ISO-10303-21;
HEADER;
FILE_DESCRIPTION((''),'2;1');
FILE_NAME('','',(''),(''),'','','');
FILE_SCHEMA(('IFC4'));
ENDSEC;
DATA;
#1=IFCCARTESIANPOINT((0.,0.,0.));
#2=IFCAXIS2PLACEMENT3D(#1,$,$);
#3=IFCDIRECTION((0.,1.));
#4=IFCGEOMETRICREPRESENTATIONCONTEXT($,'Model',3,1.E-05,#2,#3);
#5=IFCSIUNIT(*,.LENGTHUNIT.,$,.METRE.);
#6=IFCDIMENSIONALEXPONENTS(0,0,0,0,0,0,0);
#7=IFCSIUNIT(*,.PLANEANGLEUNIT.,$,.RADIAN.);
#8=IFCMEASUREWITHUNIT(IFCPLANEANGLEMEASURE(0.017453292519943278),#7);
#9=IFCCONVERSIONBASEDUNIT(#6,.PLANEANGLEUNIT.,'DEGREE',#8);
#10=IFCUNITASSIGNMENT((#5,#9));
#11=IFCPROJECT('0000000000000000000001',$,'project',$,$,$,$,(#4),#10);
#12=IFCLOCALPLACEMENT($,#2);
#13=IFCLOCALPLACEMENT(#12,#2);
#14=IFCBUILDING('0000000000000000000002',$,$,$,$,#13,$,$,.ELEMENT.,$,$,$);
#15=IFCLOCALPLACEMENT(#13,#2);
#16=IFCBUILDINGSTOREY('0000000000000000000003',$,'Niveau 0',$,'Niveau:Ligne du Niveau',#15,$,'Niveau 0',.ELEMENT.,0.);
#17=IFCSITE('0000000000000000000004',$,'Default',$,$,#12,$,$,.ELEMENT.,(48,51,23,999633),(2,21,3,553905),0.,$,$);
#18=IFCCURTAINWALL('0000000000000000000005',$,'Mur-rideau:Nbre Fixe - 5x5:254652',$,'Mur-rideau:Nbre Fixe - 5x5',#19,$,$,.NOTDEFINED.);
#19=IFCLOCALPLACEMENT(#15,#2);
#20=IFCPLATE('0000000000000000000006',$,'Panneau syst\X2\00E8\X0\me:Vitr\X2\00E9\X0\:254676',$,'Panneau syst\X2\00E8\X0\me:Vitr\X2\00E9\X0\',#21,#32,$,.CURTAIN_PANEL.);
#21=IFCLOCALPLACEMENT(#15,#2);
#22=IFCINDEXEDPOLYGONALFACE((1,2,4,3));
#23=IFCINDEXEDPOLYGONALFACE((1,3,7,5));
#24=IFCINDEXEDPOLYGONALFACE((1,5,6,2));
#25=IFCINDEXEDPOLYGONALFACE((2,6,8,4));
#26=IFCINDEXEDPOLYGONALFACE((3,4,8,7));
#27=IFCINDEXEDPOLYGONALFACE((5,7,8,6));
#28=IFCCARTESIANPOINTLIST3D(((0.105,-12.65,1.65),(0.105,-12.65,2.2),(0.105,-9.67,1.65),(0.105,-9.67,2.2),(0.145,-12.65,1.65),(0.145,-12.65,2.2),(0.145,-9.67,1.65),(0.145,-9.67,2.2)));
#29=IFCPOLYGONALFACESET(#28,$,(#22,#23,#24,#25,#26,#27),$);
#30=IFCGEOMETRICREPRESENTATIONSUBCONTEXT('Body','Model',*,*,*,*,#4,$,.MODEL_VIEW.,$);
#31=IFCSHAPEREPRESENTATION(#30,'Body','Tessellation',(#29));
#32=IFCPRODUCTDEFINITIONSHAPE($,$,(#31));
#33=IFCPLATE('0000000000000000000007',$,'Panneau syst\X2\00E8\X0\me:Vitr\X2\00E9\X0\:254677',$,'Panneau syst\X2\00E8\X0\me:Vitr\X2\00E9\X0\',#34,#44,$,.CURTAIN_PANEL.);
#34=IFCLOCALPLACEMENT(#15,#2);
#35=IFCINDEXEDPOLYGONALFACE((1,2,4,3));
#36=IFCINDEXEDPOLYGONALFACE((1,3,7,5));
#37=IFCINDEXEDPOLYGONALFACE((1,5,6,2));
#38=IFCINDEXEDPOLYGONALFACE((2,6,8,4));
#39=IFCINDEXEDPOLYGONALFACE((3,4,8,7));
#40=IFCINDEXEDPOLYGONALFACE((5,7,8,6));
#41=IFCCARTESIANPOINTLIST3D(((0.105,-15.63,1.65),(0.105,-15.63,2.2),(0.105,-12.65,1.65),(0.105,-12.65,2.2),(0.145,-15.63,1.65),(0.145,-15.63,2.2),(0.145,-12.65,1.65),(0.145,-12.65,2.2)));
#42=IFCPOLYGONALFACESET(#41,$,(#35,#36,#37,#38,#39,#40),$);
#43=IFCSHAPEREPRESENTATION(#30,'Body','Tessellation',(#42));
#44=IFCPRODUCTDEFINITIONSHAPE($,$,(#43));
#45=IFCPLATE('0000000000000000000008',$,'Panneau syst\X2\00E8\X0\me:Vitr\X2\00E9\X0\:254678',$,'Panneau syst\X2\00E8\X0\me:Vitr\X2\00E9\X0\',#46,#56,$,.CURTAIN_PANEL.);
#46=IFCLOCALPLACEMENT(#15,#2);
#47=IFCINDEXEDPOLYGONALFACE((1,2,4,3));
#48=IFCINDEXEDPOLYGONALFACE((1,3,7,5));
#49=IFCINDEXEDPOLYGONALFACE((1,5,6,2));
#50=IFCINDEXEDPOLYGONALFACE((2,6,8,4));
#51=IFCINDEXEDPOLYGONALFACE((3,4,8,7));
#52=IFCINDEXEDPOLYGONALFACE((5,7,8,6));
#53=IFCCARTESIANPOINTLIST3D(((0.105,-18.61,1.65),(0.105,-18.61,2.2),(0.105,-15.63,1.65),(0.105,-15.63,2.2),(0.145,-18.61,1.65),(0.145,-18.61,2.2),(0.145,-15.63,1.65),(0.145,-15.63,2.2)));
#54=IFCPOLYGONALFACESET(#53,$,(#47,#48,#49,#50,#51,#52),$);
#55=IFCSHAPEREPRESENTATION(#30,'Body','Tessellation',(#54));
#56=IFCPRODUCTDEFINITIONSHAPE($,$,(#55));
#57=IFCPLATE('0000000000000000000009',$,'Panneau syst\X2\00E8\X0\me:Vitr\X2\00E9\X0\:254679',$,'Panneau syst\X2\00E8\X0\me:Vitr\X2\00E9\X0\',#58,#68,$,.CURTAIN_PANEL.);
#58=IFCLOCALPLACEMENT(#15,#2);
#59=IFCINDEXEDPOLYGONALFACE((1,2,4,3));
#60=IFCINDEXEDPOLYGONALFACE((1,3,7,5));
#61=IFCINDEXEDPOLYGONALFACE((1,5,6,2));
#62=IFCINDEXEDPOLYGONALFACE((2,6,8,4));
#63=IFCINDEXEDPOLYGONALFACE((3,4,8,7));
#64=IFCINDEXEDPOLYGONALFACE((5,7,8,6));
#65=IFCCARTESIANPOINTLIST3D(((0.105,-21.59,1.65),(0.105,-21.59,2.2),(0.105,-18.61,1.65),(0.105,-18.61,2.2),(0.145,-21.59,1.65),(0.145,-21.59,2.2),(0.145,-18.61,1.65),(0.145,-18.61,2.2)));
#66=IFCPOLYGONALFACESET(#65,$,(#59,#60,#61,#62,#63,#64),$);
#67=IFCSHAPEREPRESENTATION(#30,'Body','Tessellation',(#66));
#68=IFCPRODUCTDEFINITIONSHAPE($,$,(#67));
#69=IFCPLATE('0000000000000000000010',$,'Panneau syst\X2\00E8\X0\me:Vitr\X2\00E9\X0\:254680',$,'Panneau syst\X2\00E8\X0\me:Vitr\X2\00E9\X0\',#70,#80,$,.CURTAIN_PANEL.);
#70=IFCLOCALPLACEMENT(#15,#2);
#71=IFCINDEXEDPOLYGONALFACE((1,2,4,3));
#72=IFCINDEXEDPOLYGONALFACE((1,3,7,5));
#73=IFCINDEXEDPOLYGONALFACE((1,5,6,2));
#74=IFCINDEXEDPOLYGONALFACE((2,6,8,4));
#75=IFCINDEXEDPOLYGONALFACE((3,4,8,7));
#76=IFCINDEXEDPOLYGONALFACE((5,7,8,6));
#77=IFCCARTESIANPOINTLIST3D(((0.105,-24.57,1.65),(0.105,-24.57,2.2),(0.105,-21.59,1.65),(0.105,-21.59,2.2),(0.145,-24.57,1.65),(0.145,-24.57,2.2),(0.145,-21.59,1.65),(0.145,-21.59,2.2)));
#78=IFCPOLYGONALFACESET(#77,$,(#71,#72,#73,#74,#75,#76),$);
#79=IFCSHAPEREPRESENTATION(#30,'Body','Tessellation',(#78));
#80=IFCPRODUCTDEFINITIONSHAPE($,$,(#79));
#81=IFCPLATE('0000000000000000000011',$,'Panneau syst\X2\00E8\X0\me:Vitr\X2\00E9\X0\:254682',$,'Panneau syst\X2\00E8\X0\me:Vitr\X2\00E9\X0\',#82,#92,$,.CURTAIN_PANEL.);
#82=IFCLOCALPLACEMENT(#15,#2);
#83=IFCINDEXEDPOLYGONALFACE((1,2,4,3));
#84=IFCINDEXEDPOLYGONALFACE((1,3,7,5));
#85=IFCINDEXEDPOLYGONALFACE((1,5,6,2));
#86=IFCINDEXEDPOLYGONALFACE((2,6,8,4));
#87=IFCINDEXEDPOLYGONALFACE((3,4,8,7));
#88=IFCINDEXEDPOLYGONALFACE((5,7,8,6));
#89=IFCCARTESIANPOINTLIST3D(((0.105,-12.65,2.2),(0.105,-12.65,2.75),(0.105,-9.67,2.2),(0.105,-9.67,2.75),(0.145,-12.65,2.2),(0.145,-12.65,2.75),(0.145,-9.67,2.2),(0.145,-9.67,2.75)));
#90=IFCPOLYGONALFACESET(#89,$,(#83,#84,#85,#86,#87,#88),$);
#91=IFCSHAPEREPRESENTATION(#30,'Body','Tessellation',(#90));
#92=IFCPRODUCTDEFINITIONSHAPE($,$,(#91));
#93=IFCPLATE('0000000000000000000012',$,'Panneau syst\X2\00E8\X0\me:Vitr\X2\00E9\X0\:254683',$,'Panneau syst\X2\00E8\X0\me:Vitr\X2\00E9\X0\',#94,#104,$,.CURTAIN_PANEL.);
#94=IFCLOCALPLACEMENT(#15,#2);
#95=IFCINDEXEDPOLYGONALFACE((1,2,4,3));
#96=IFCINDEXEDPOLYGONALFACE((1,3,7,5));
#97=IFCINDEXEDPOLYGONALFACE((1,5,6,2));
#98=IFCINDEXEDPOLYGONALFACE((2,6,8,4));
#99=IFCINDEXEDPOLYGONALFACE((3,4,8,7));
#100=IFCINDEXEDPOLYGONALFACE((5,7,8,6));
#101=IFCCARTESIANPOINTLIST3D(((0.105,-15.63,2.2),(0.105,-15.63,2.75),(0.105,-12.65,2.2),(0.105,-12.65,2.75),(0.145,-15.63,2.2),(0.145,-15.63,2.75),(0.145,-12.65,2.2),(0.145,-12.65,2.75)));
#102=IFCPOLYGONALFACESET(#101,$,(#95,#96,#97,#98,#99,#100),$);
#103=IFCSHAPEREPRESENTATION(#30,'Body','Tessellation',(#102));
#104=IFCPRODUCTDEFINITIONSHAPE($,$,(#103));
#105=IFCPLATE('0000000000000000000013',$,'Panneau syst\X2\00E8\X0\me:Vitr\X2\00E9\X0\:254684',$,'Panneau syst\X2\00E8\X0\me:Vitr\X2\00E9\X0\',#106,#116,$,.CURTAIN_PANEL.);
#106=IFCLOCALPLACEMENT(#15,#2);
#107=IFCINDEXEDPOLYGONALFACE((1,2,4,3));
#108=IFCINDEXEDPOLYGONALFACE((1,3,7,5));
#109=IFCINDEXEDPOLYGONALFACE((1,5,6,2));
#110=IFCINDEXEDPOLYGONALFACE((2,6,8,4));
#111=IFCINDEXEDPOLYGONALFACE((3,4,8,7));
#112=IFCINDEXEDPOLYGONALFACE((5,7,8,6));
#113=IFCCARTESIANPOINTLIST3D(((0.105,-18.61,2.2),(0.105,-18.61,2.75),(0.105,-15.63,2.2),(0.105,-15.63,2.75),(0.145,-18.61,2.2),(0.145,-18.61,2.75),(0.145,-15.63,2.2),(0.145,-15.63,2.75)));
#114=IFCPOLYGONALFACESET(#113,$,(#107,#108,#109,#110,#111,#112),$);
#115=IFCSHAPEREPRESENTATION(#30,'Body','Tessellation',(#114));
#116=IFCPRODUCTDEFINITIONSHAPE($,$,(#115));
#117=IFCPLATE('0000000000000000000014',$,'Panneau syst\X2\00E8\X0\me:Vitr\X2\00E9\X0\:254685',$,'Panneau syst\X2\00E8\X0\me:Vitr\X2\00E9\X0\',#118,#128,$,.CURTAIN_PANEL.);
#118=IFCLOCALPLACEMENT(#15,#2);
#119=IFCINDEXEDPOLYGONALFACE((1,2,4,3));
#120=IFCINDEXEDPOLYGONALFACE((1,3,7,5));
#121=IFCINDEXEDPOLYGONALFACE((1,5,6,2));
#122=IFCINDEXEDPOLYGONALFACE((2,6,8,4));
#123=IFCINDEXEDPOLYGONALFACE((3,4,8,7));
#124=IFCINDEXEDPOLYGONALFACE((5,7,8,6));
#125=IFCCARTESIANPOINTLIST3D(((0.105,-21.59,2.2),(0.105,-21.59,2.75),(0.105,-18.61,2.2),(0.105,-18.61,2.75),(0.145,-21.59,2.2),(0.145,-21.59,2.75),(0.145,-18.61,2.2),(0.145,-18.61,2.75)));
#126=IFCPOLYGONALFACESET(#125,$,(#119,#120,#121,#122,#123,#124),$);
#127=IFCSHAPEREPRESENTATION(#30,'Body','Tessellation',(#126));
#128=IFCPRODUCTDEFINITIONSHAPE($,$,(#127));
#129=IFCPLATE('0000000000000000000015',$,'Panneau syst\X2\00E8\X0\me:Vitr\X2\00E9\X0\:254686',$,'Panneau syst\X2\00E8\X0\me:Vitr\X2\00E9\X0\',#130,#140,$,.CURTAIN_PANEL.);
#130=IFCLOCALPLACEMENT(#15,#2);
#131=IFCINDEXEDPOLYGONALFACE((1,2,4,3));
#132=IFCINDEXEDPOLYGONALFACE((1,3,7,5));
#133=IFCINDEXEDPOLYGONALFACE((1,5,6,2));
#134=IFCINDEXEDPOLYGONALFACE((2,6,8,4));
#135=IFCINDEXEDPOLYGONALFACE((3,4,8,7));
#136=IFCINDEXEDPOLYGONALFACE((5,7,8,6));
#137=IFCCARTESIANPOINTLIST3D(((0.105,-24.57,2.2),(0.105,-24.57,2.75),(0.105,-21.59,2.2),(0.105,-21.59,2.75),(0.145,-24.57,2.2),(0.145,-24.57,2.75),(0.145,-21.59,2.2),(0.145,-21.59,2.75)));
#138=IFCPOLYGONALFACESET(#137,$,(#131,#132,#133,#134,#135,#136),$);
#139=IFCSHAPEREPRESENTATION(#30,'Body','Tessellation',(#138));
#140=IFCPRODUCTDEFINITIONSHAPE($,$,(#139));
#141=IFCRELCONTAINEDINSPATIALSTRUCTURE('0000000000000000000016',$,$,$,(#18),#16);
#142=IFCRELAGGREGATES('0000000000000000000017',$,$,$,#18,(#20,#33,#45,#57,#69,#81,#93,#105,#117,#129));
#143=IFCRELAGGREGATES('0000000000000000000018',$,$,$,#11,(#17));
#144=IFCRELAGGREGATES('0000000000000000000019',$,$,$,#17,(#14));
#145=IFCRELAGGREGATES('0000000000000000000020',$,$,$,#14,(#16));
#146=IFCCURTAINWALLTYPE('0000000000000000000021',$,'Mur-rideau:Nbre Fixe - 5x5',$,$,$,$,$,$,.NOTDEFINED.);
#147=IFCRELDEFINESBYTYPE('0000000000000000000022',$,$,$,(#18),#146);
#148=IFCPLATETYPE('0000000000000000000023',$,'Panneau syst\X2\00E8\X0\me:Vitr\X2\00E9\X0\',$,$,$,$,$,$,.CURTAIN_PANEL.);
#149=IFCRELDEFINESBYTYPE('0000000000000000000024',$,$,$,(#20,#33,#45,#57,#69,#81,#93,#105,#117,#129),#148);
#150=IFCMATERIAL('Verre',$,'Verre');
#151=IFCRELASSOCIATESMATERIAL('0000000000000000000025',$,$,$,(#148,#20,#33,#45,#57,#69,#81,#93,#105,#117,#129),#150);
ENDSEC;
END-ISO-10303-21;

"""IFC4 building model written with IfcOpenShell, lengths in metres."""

from ifc_helpers import new_model, entity, si_unit, converted_unit, direction, frame, origin, place, context, subcontext, project, spatial, indexed_curve, outline, extrude, source, transform, mapped, material, type_object, type_shapes, element, aggregate, save


model = new_model("IFC4")

# Units and contexts
model_context = context("Model", 3, precision=1e-05, world=origin(), true_north=direction((0.0, 1.0)))
body_context = subcontext(model_context, "Body", "Model", "MODEL_VIEW")
ifc_project = project(units=[si_unit("LENGTHUNIT", "METRE"), converted_unit("PLANEANGLEUNIT", "DEGREE", entity("IfcPlaneAngleMeasure", 0.017453292519943278), si_unit("PLANEANGLEUNIT", "RADIAN"), dimensions=[0, 0, 0, 0, 0, 0, 0])], contexts=[model_context])

# Site, building, storey
site_placement = place(None, origin())
site = spatial("IfcSite", under=ifc_project, at=site_placement, Name="Default", CompositionType="ELEMENT", RefLatitude=(48, 51, 23, 999633), RefLongitude=(2, 21, 3, 553905), RefElevation=0.0)
building_placement = place(site_placement, origin())
building = spatial("IfcBuilding", under=site, at=building_placement, CompositionType="ELEMENT")
storey_placement = place(building_placement, origin())
storey = spatial("IfcBuildingStorey", under=building, at=storey_placement, Name="Niveau 0", ObjectType="Niveau:Ligne du Niveau", LongName="Niveau 0", CompositionType="ELEMENT", Elevation=0.0)

# Curtain wall, plates
curtain_wall_type = type_object("IfcCurtainWallType", Name="Mur-rideau:Nbre Fixe - 5x5", PredefinedType="NOTDEFINED")
curtain_wall_placement = place(storey_placement, origin())
curtain_wall = element("IfcCurtainWall", 1, at=curtain_wall_placement, inside=storey, type_object=curtain_wall_type, Name="Mur-rideau:Nbre Fixe - 5x5:254652", ObjectType="Mur-rideau:Nbre Fixe - 5x5", PredefinedType="NOTDEFINED")
ifc_material = material(Name="Verre", Category="Verre")
plate_type = type_object("IfcPlateType", Name="Panneau système:Vitré", PredefinedType="CURTAIN_PANEL", material=ifc_material)
shared_shape = source(origin(), body_context, "Body", "SweptSolid", [
    extrude(outline(indexed_curve([(-0.02, -1.49), (0.02, -1.49), (0.02, 1.49), (-0.02, 1.49), (-0.02, -1.49)], self_intersect=False)), frame((1.49, 0.02, 0.0), z_axis=(0.0, 0.0, 1.0), x_axis=(0.0, 1.0, 0.0)), (0.0, 0.0, 1.0), 0.55),
])
type_shapes(plate_type, [shared_shape])
plate_1_placement = place(curtain_wall_placement, frame((0.105, -9.67, 1.65), z_axis=(0.0, 0.0, 1.0), x_axis=(0.0, -1.0, 0.0)))
plate_1 = element("IfcPlate", 2, at=plate_1_placement, type_object=plate_type, material=ifc_material, Name="Panneau système:Vitré:254676", ObjectType="Panneau système:Vitré", PredefinedType="CURTAIN_PANEL", context=body_context, shape_type="MappedRepresentation", body=[
    mapped(shared_shape, transform((0.0, 0.0, 0.0), scale=1.0)),
])
plate_2_placement = place(curtain_wall_placement, frame((0.105, -12.65, 1.65), z_axis=(0.0, 0.0, 1.0), x_axis=(0.0, -1.0, 0.0)))
plate_2 = element("IfcPlate", 3, at=plate_2_placement, type_object=plate_type, material=ifc_material, Name="Panneau système:Vitré:254677", ObjectType="Panneau système:Vitré", PredefinedType="CURTAIN_PANEL", context=body_context, shape_type="MappedRepresentation", body=[
    mapped(shared_shape, transform((0.0, 0.0, 0.0), scale=1.0)),
])
plate_3_placement = place(curtain_wall_placement, frame((0.105, -15.63, 1.65), z_axis=(0.0, 0.0, 1.0), x_axis=(0.0, -1.0, 0.0)))
plate_3 = element("IfcPlate", 4, at=plate_3_placement, type_object=plate_type, material=ifc_material, Name="Panneau système:Vitré:254678", ObjectType="Panneau système:Vitré", PredefinedType="CURTAIN_PANEL", context=body_context, shape_type="MappedRepresentation", body=[
    mapped(shared_shape, transform((0.0, 0.0, 0.0), scale=1.0)),
])
plate_4_placement = place(curtain_wall_placement, frame((0.105, -18.61, 1.65), z_axis=(0.0, 0.0, 1.0), x_axis=(0.0, -1.0, 0.0)))
plate_4 = element("IfcPlate", 5, at=plate_4_placement, type_object=plate_type, material=ifc_material, Name="Panneau système:Vitré:254679", ObjectType="Panneau système:Vitré", PredefinedType="CURTAIN_PANEL", context=body_context, shape_type="MappedRepresentation", body=[
    mapped(shared_shape, transform((0.0, 0.0, 0.0), scale=1.0)),
])
plate_5_placement = place(curtain_wall_placement, frame((0.105, -21.59, 1.65), z_axis=(0.0, 0.0, 1.0), x_axis=(0.0, -1.0, 0.0)))
plate_5 = element("IfcPlate", 6, at=plate_5_placement, type_object=plate_type, material=ifc_material, Name="Panneau système:Vitré:254680", ObjectType="Panneau système:Vitré", PredefinedType="CURTAIN_PANEL", context=body_context, shape_type="MappedRepresentation", body=[
    mapped(shared_shape, transform((0.0, 0.0, 0.0), scale=1.0)),
])
plate_6_placement = place(curtain_wall_placement, frame((0.105, -9.67, 2.2), z_axis=(0.0, 0.0, 1.0), x_axis=(0.0, -1.0, 0.0)))
plate_6 = element("IfcPlate", 7, at=plate_6_placement, type_object=plate_type, material=ifc_material, Name="Panneau système:Vitré:254682", ObjectType="Panneau système:Vitré", PredefinedType="CURTAIN_PANEL", context=body_context, shape_type="MappedRepresentation", body=[
    mapped(shared_shape, transform((0.0, 0.0, 0.0), scale=1.0)),
])
plate_7_placement = place(curtain_wall_placement, frame((0.105, -12.65, 2.2), z_axis=(0.0, 0.0, 1.0), x_axis=(0.0, -1.0, 0.0)))
plate_7 = element("IfcPlate", 8, at=plate_7_placement, type_object=plate_type, material=ifc_material, Name="Panneau système:Vitré:254683", ObjectType="Panneau système:Vitré", PredefinedType="CURTAIN_PANEL", context=body_context, shape_type="MappedRepresentation", body=[
    mapped(shared_shape, transform((0.0, 0.0, 0.0), scale=1.0)),
])
plate_8_placement = place(curtain_wall_placement, frame((0.105, -15.63, 2.2), z_axis=(0.0, 0.0, 1.0), x_axis=(0.0, -1.0, 0.0)))
plate_8 = element("IfcPlate", 9, at=plate_8_placement, type_object=plate_type, material=ifc_material, Name="Panneau système:Vitré:254684", ObjectType="Panneau système:Vitré", PredefinedType="CURTAIN_PANEL", context=body_context, shape_type="MappedRepresentation", body=[
    mapped(shared_shape, transform((0.0, 0.0, 0.0), scale=1.0)),
])
plate_9_placement = place(curtain_wall_placement, frame((0.105, -18.61, 2.2), z_axis=(0.0, 0.0, 1.0), x_axis=(0.0, -1.0, 0.0)))
plate_9 = element("IfcPlate", 10, at=plate_9_placement, type_object=plate_type, material=ifc_material, Name="Panneau système:Vitré:254685", ObjectType="Panneau système:Vitré", PredefinedType="CURTAIN_PANEL", context=body_context, shape_type="MappedRepresentation", body=[
    mapped(shared_shape, transform((0.0, 0.0, 0.0), scale=1.0)),
])
plate_10_placement = place(curtain_wall_placement, frame((0.105, -21.59, 2.2), z_axis=(0.0, 0.0, 1.0), x_axis=(0.0, -1.0, 0.0)))
plate_10 = element("IfcPlate", 11, at=plate_10_placement, type_object=plate_type, material=ifc_material, Name="Panneau système:Vitré:254686", ObjectType="Panneau système:Vitré", PredefinedType="CURTAIN_PANEL", context=body_context, shape_type="MappedRepresentation", body=[
    mapped(shared_shape, transform((0.0, 0.0, 0.0), scale=1.0)),
])
aggregate(curtain_wall, [plate_1, plate_2, plate_3, plate_4, plate_5, plate_6, plate_7, plate_8, plate_9, plate_10])

save(model, "model.ifc")
